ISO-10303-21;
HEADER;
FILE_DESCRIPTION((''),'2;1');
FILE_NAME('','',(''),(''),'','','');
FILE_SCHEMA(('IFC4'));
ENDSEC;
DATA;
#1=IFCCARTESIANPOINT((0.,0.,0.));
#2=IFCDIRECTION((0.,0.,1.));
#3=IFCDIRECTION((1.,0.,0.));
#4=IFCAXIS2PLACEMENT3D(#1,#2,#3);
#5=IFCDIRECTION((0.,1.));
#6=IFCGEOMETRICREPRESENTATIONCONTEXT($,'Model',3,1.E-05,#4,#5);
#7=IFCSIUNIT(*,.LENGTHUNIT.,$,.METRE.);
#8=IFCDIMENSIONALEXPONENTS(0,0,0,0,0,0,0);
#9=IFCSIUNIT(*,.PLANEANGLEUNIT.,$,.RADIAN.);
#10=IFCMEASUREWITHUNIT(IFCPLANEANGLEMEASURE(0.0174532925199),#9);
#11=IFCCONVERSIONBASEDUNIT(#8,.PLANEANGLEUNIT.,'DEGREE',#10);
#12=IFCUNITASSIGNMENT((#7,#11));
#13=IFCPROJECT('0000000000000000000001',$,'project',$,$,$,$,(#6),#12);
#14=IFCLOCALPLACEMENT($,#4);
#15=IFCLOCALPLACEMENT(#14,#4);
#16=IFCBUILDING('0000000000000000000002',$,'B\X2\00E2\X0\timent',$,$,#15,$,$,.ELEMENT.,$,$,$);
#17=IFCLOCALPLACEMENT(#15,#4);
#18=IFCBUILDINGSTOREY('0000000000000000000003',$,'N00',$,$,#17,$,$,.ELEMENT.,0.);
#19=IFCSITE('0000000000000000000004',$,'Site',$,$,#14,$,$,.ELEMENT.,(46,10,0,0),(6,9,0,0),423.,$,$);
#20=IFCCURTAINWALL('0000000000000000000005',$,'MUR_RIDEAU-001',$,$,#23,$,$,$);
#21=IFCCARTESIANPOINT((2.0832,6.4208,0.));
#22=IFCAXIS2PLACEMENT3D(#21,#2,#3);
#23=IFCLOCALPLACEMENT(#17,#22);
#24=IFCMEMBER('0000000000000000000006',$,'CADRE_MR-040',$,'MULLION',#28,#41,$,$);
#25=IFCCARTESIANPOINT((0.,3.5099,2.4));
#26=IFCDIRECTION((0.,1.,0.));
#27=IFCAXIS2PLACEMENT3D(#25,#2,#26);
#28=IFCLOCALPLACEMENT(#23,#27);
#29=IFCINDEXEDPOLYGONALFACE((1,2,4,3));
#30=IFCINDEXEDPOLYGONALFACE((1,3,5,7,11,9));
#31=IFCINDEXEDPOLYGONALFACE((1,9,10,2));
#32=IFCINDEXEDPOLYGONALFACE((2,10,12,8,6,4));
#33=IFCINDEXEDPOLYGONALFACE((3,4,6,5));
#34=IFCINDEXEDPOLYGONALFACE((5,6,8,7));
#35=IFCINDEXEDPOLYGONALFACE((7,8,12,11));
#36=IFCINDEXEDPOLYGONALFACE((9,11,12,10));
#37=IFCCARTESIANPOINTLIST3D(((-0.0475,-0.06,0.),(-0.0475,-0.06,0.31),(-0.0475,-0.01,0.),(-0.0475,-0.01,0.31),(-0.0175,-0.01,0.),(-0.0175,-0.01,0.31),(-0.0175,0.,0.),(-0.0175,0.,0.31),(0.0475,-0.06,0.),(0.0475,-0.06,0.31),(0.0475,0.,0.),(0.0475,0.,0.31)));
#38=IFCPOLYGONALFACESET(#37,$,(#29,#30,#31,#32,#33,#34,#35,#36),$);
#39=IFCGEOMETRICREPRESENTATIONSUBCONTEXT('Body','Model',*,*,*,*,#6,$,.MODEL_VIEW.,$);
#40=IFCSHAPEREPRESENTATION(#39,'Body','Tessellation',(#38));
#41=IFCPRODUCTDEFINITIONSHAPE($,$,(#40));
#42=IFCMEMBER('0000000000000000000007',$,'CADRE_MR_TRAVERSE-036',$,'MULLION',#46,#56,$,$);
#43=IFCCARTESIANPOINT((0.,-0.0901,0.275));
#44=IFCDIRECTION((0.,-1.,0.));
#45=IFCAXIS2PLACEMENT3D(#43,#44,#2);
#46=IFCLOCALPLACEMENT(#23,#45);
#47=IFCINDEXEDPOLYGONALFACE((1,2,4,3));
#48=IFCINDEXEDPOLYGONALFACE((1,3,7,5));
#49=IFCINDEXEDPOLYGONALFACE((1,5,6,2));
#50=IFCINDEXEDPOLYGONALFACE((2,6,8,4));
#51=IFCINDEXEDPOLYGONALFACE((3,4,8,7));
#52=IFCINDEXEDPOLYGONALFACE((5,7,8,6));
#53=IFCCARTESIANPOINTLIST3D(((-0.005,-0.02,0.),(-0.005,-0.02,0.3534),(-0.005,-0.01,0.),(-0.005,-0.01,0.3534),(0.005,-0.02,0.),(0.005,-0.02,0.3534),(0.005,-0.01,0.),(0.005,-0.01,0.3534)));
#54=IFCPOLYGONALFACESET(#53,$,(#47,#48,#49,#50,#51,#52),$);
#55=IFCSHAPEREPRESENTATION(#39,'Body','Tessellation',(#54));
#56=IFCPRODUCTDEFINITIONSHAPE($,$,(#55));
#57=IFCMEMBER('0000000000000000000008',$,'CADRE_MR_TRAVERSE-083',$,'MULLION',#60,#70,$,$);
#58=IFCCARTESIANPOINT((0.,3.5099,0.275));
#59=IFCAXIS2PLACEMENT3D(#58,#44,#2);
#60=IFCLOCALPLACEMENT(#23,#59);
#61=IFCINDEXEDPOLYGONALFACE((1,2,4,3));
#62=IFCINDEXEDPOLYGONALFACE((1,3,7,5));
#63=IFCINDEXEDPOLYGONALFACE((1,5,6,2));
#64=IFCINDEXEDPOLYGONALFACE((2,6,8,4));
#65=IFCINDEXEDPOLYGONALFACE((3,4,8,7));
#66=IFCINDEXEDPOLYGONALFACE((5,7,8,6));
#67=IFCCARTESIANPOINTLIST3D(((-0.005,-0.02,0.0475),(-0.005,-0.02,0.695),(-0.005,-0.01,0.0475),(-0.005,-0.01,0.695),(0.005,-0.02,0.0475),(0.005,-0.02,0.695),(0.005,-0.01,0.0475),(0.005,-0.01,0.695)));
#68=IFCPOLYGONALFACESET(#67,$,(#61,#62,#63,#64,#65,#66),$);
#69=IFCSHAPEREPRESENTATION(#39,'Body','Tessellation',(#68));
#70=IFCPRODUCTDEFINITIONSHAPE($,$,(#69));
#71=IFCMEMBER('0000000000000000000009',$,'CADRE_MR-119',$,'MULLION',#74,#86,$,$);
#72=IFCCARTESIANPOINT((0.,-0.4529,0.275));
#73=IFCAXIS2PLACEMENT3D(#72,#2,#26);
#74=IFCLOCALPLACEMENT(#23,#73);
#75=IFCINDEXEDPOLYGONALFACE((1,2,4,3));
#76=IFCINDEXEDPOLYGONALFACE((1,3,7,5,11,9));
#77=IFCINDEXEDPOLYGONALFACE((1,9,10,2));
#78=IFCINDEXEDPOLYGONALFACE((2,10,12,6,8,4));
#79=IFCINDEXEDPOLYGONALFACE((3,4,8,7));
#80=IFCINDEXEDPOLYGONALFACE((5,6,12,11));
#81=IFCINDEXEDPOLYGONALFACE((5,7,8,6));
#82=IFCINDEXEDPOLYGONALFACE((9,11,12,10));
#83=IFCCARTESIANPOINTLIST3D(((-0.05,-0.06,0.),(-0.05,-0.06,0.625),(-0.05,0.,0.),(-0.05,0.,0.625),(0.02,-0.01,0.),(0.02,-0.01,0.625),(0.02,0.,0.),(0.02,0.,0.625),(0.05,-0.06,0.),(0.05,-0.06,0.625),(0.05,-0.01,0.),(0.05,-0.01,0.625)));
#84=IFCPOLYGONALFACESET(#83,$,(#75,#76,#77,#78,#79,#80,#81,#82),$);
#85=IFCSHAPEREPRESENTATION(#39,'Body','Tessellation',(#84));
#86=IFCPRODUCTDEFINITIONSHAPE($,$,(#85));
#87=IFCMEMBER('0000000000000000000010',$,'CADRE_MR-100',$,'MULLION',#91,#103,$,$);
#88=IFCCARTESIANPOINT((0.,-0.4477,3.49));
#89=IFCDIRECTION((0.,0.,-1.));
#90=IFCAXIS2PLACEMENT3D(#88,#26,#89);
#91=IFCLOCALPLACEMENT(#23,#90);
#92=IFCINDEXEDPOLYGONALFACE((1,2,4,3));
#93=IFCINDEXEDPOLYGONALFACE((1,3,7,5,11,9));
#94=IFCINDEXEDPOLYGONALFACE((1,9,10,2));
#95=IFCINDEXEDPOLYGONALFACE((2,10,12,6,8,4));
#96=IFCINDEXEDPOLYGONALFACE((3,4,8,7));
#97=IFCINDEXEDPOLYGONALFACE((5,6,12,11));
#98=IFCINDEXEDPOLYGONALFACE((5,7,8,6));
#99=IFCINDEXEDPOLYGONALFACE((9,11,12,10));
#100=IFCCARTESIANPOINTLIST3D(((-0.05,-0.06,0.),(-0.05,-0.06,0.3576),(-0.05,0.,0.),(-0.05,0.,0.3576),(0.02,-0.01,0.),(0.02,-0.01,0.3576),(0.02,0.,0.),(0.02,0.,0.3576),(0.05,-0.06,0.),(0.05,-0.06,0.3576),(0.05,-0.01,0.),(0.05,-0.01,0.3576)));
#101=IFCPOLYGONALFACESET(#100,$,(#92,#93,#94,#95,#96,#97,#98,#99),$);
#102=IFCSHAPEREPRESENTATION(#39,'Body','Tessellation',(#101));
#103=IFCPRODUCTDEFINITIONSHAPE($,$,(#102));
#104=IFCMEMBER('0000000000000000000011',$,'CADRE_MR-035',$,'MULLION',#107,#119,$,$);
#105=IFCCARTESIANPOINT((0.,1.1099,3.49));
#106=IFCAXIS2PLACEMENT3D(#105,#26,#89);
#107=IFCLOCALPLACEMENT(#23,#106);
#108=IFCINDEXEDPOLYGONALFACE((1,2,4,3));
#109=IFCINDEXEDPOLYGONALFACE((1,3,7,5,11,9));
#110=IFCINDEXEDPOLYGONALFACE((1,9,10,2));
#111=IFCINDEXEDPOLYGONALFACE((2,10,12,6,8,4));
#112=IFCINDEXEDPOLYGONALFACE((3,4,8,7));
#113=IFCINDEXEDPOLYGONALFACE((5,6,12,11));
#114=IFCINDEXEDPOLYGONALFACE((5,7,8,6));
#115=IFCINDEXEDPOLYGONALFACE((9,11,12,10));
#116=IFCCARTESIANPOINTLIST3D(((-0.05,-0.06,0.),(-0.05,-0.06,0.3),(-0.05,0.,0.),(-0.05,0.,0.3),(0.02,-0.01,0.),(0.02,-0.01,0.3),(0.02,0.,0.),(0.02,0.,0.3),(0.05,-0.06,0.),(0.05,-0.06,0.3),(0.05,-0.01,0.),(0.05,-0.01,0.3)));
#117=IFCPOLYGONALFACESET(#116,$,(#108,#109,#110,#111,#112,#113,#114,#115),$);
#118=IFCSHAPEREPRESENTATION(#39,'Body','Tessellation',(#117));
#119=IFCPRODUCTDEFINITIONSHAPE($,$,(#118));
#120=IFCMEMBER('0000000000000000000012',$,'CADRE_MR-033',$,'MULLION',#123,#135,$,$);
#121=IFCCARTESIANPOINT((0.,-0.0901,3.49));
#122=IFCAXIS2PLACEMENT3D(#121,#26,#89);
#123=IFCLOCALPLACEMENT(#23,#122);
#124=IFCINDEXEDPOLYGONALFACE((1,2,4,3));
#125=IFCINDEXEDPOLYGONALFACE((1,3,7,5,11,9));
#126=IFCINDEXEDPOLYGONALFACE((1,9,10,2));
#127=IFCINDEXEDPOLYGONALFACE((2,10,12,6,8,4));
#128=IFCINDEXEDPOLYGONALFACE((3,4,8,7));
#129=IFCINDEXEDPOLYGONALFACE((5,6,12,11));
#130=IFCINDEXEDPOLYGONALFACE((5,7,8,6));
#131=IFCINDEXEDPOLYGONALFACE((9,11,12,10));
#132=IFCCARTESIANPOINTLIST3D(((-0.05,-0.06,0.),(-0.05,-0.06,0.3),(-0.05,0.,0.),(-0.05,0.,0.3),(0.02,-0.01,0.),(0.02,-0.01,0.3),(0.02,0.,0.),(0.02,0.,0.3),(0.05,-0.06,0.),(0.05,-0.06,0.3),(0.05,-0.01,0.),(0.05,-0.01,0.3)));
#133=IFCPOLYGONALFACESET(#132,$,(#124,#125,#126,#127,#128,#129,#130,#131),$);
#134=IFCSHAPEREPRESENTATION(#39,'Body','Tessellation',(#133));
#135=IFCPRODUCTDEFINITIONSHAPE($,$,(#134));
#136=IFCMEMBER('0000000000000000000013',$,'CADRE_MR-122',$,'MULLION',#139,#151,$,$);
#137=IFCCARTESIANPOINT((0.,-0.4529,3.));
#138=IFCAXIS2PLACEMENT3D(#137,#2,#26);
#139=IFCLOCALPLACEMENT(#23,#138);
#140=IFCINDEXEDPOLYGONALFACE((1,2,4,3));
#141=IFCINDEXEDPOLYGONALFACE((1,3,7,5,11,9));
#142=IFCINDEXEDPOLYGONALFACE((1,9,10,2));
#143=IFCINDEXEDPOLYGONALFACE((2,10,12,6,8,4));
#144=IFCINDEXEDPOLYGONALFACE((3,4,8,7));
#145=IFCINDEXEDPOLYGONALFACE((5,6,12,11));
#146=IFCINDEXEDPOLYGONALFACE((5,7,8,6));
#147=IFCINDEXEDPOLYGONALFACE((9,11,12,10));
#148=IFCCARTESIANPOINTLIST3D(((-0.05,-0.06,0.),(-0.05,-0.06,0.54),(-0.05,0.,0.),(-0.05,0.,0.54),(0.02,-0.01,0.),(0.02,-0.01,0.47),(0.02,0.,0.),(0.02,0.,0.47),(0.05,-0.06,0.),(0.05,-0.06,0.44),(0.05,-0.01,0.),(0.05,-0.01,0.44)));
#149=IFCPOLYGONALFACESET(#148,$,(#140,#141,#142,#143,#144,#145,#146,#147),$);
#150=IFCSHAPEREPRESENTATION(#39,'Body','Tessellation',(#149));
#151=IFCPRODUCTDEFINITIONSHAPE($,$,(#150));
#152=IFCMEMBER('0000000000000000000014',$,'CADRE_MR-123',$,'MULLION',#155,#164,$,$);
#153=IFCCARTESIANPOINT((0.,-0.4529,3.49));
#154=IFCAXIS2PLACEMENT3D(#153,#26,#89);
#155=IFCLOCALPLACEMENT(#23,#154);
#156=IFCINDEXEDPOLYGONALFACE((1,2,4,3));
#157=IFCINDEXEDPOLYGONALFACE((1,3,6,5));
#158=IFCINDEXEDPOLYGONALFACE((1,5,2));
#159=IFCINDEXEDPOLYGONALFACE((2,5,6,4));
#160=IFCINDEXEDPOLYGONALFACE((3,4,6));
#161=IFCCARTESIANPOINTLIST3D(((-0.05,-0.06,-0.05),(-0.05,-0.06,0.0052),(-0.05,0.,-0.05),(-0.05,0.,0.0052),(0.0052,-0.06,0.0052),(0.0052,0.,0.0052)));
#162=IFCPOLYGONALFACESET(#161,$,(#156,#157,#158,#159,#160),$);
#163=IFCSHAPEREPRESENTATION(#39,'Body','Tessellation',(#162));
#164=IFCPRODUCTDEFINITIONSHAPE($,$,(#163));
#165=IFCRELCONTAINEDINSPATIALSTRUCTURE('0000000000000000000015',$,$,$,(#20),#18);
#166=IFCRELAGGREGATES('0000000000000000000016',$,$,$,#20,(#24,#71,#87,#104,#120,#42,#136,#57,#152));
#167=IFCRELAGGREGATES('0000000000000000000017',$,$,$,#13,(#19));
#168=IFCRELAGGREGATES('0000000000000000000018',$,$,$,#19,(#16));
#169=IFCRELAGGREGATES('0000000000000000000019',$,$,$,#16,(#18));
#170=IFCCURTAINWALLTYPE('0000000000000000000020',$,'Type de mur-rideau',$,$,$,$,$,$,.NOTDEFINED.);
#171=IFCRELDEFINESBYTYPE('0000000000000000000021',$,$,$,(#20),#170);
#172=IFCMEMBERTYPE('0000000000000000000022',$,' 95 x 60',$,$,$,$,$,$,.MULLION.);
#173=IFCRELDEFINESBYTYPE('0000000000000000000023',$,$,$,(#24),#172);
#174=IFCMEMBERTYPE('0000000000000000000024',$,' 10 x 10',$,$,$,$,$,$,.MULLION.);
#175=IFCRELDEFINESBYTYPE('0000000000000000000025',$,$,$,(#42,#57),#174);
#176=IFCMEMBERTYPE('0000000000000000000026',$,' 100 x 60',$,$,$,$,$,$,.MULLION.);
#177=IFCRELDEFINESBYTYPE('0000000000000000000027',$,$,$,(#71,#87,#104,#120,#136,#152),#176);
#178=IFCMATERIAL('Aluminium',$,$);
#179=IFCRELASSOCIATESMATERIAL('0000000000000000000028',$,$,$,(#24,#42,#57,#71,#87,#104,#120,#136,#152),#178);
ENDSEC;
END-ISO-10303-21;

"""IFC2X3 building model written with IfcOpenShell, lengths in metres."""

from ifc_helpers import new_model, entity, si_unit, converted_unit, direction, frame, origin_with_axes, place, context, subcontext, project, spatial, polyline, outline, extrude, clip, halfspace, material, type_object, element, aggregate, save


model = new_model("IFC2X3")

# Units and contexts
model_context = context("Model", 3, precision=1e-05, world=origin_with_axes(), true_north=direction((0.0, 1.0)))
body_context = subcontext(model_context, "Body", "Model", "MODEL_VIEW")
ifc_project = project(units=[si_unit("LENGTHUNIT", "METRE"), converted_unit("PLANEANGLEUNIT", "DEGREE", entity("IfcPlaneAngleMeasure", 0.0174532925199), si_unit("PLANEANGLEUNIT", "RADIAN"), dimensions=[0, 0, 0, 0, 0, 0, 0])], contexts=[model_context])

# Site, building, storey
site_placement = place(None, origin_with_axes())
site = spatial("IfcSite", under=ifc_project, at=site_placement, Name="Site", CompositionType="ELEMENT", RefLatitude=(46, 10, 0, 0), RefLongitude=(6, 9, 0, 0), RefElevation=423.0)
building_placement = place(site_placement, origin_with_axes())
building = spatial("IfcBuilding", under=site, at=building_placement, Name="Bâtiment", CompositionType="ELEMENT")
storey_placement = place(building_placement, origin_with_axes())
storey = spatial("IfcBuildingStorey", under=building, at=storey_placement, Name="N00", CompositionType="ELEMENT", Elevation=0.0)

# Curtain wall, members
curtain_wall_type = type_object("IfcCurtainWallType", Name="Type de mur-rideau", PredefinedType="NOTDEFINED")
curtain_wall_placement = place(storey_placement, frame((2.0832, 6.4208, 0.0), z_axis=(0.0, 0.0, 1.0), x_axis=(1.0, 0.0, 0.0)))
curtain_wall = element("IfcCurtainWall", 1, at=curtain_wall_placement, inside=storey, type_object=curtain_wall_type, Name="MUR_RIDEAU-001")
ifc_material = material(Name="Aluminium")
member_type_1 = type_object("IfcMemberType", Name=" 95 x 60", PredefinedType="MULLION")
member_1_placement = place(curtain_wall_placement, frame((0.0, 3.5099, 2.4), z_axis=(0.0, 0.0, 1.0), x_axis=(0.0, 1.0, 0.0)))
member_1 = element("IfcMember", 2, at=member_1_placement, type_object=member_type_1, material=ifc_material, Name="CADRE_MR-040", ObjectType="MULLION", context=body_context, shape_type="SweptSolid", body=[
    extrude(outline(polyline([(0.01, -0.0175), (0.01, -0.0475), (0.06, -0.0475), (0.06, 0.0475), (0.0, 0.0475), (0.0, -0.0175), (0.01, -0.0175)])), frame((0.0, 0.0, 0.0), z_axis=(0.0, 0.0, 1.0), x_axis=(0.0, -1.0, 0.0)), (0.0, 0.0, 1.0), 0.31),
])
member_type_2 = type_object("IfcMemberType", Name=" 10 x 10", PredefinedType="MULLION")
member_2_placement = place(curtain_wall_placement, frame((0.0, -0.0901, 0.275), z_axis=(0.0, -1.0, 0.0), x_axis=(0.0, 0.0, 1.0)))
member_2 = element("IfcMember", 3, at=member_2_placement, type_object=member_type_2, material=ifc_material, Name="CADRE_MR_TRAVERSE-036", ObjectType="MULLION", context=body_context, shape_type="SweptSolid", body=[
    extrude(outline(polyline([(-0.02, -0.005), (-0.01, -0.005), (-0.01, 0.005), (-0.02, 0.005), (-0.02, -0.005)])), frame((0.0, 0.0, 0.0), z_axis=(0.0, 0.0, 1.0), x_axis=(0.0, 1.0, 0.0)), (0.0, 0.0, 1.0), 0.3534),
])
member_3_placement = place(curtain_wall_placement, frame((0.0, 3.5099, 0.275), z_axis=(0.0, -1.0, 0.0), x_axis=(0.0, 0.0, 1.0)))
member_3 = element("IfcMember", 4, at=member_3_placement, type_object=member_type_2, material=ifc_material, Name="CADRE_MR_TRAVERSE-083", ObjectType="MULLION", context=body_context, shape_type="SweptSolid", body=[
    extrude(outline(polyline([(-0.02, -0.005), (-0.01, -0.005), (-0.01, 0.005), (-0.02, 0.005), (-0.02, -0.005)])), frame((0.0, 0.0, 0.0475), z_axis=(0.0, 0.0, 1.0), x_axis=(0.0, 1.0, 0.0)), (0.0, 0.0, 1.0), 0.6475),
])
member_type_3 = type_object("IfcMemberType", Name=" 100 x 60", PredefinedType="MULLION")
member_4_placement = place(curtain_wall_placement, frame((0.0, -0.4529, 0.275), z_axis=(0.0, 0.0, 1.0), x_axis=(0.0, 1.0, 0.0)))
member_4 = element("IfcMember", 5, at=member_4_placement, type_object=member_type_3, material=ifc_material, Name="CADRE_MR-119", ObjectType="MULLION", context=body_context, shape_type="SweptSolid", body=[
    extrude(outline(polyline([(0.01, 0.02), (0.0, 0.02), (0.0, -0.05), (0.06, -0.05), (0.06, 0.05), (0.01, 0.05), (0.01, 0.02)])), frame((0.0, 0.0, 0.0), z_axis=(0.0, 0.0, 1.0), x_axis=(0.0, -1.0, 0.0)), (0.0, 0.0, 1.0), 0.625),
])
member_5_placement = place(curtain_wall_placement, frame((0.0, -0.4477, 3.49), z_axis=(0.0, 1.0, 0.0), x_axis=(0.0, 0.0, -1.0)))
member_5 = element("IfcMember", 6, at=member_5_placement, type_object=member_type_3, material=ifc_material, Name="CADRE_MR-100", ObjectType="MULLION", context=body_context, shape_type="SweptSolid", body=[
    extrude(outline(polyline([(0.01, 0.02), (0.0, 0.02), (0.0, -0.05), (0.06, -0.05), (0.06, 0.05), (0.01, 0.05), (0.01, 0.02)])), frame((0.0, 0.0, 0.0), z_axis=(0.0, 0.0, 1.0), x_axis=(0.0, -1.0, 0.0)), (0.0, 0.0, 1.0), 0.3576),
])
member_6_placement = place(curtain_wall_placement, frame((0.0, 1.1099, 3.49), z_axis=(0.0, 1.0, 0.0), x_axis=(0.0, 0.0, -1.0)))
member_6 = element("IfcMember", 7, at=member_6_placement, type_object=member_type_3, material=ifc_material, Name="CADRE_MR-035", ObjectType="MULLION", context=body_context, shape_type="SweptSolid", body=[
    extrude(outline(polyline([(0.01, 0.02), (0.0, 0.02), (0.0, -0.05), (0.06, -0.05), (0.06, 0.05), (0.01, 0.05), (0.01, 0.02)])), frame((0.0, 0.0, 0.0), z_axis=(0.0, 0.0, 1.0), x_axis=(0.0, -1.0, 0.0)), (0.0, 0.0, 1.0), 0.3),
])
member_7_placement = place(curtain_wall_placement, frame((0.0, -0.0901, 3.49), z_axis=(0.0, 1.0, 0.0), x_axis=(0.0, 0.0, -1.0)))
member_7 = element("IfcMember", 8, at=member_7_placement, type_object=member_type_3, material=ifc_material, Name="CADRE_MR-033", ObjectType="MULLION", context=body_context, shape_type="SweptSolid", body=[
    extrude(outline(polyline([(0.01, 0.02), (0.0, 0.02), (0.0, -0.05), (0.06, -0.05), (0.06, 0.05), (0.01, 0.05), (0.01, 0.02)])), frame((0.0, 0.0, 0.0), z_axis=(0.0, 0.0, 1.0), x_axis=(0.0, -1.0, 0.0)), (0.0, 0.0, 1.0), 0.3),
])
member_8_placement = place(curtain_wall_placement, frame((0.0, -0.4529, 3.0), z_axis=(0.0, 0.0, 1.0), x_axis=(0.0, 1.0, 0.0)))
member_8 = element("IfcMember", 9, at=member_8_placement, type_object=member_type_3, material=ifc_material, Name="CADRE_MR-122", ObjectType="MULLION", context=body_context, shape_type="Clipping", body=[
    clip(extrude(outline(polyline([(0.01, 0.02), (0.0, 0.02), (0.0, -0.05), (0.06, -0.05), (0.06, 0.05), (0.01, 0.05), (0.01, 0.02)])), frame((0.0, 0.0, 0.0), z_axis=(0.0, 0.0, 1.0), x_axis=(0.0, -1.0, 0.0)), (0.0, 0.0, 1.0), 0.54), halfspace(frame((0.245, 0.0, 0.245), z_axis=(-0.707107, 0.0, -0.707107), x_axis=(0.0, 1.0, 0.0)), True)),
])
member_9_placement = place(curtain_wall_placement, frame((0.0, -0.4529, 3.49), z_axis=(0.0, 1.0, 0.0), x_axis=(0.0, 0.0, -1.0)))
member_9 = element("IfcMember", 10, at=member_9_placement, type_object=member_type_3, material=ifc_material, Name="CADRE_MR-123", ObjectType="MULLION", context=body_context, shape_type="Clipping", body=[
    clip(extrude(outline(polyline([(0.0, 0.0052), (0.0, -0.05), (0.06, -0.05), (0.06, 0.0052), (0.0, 0.0052)])), frame((0.0, 0.0, -0.05), z_axis=(0.0, 0.0, 1.0), x_axis=(0.0, -1.0, 0.0)), (0.0, 0.0, 1.0), 0.0552), halfspace(frame((0.0, 0.0, 0.0), z_axis=(-0.707107, 0.0, 0.707107), x_axis=(0.0, -1.0, 0.0)), True)),
])
aggregate(curtain_wall, [member_1, member_4, member_5, member_6, member_7, member_2, member_8, member_3, member_9])

save(model, "model.ifc")
